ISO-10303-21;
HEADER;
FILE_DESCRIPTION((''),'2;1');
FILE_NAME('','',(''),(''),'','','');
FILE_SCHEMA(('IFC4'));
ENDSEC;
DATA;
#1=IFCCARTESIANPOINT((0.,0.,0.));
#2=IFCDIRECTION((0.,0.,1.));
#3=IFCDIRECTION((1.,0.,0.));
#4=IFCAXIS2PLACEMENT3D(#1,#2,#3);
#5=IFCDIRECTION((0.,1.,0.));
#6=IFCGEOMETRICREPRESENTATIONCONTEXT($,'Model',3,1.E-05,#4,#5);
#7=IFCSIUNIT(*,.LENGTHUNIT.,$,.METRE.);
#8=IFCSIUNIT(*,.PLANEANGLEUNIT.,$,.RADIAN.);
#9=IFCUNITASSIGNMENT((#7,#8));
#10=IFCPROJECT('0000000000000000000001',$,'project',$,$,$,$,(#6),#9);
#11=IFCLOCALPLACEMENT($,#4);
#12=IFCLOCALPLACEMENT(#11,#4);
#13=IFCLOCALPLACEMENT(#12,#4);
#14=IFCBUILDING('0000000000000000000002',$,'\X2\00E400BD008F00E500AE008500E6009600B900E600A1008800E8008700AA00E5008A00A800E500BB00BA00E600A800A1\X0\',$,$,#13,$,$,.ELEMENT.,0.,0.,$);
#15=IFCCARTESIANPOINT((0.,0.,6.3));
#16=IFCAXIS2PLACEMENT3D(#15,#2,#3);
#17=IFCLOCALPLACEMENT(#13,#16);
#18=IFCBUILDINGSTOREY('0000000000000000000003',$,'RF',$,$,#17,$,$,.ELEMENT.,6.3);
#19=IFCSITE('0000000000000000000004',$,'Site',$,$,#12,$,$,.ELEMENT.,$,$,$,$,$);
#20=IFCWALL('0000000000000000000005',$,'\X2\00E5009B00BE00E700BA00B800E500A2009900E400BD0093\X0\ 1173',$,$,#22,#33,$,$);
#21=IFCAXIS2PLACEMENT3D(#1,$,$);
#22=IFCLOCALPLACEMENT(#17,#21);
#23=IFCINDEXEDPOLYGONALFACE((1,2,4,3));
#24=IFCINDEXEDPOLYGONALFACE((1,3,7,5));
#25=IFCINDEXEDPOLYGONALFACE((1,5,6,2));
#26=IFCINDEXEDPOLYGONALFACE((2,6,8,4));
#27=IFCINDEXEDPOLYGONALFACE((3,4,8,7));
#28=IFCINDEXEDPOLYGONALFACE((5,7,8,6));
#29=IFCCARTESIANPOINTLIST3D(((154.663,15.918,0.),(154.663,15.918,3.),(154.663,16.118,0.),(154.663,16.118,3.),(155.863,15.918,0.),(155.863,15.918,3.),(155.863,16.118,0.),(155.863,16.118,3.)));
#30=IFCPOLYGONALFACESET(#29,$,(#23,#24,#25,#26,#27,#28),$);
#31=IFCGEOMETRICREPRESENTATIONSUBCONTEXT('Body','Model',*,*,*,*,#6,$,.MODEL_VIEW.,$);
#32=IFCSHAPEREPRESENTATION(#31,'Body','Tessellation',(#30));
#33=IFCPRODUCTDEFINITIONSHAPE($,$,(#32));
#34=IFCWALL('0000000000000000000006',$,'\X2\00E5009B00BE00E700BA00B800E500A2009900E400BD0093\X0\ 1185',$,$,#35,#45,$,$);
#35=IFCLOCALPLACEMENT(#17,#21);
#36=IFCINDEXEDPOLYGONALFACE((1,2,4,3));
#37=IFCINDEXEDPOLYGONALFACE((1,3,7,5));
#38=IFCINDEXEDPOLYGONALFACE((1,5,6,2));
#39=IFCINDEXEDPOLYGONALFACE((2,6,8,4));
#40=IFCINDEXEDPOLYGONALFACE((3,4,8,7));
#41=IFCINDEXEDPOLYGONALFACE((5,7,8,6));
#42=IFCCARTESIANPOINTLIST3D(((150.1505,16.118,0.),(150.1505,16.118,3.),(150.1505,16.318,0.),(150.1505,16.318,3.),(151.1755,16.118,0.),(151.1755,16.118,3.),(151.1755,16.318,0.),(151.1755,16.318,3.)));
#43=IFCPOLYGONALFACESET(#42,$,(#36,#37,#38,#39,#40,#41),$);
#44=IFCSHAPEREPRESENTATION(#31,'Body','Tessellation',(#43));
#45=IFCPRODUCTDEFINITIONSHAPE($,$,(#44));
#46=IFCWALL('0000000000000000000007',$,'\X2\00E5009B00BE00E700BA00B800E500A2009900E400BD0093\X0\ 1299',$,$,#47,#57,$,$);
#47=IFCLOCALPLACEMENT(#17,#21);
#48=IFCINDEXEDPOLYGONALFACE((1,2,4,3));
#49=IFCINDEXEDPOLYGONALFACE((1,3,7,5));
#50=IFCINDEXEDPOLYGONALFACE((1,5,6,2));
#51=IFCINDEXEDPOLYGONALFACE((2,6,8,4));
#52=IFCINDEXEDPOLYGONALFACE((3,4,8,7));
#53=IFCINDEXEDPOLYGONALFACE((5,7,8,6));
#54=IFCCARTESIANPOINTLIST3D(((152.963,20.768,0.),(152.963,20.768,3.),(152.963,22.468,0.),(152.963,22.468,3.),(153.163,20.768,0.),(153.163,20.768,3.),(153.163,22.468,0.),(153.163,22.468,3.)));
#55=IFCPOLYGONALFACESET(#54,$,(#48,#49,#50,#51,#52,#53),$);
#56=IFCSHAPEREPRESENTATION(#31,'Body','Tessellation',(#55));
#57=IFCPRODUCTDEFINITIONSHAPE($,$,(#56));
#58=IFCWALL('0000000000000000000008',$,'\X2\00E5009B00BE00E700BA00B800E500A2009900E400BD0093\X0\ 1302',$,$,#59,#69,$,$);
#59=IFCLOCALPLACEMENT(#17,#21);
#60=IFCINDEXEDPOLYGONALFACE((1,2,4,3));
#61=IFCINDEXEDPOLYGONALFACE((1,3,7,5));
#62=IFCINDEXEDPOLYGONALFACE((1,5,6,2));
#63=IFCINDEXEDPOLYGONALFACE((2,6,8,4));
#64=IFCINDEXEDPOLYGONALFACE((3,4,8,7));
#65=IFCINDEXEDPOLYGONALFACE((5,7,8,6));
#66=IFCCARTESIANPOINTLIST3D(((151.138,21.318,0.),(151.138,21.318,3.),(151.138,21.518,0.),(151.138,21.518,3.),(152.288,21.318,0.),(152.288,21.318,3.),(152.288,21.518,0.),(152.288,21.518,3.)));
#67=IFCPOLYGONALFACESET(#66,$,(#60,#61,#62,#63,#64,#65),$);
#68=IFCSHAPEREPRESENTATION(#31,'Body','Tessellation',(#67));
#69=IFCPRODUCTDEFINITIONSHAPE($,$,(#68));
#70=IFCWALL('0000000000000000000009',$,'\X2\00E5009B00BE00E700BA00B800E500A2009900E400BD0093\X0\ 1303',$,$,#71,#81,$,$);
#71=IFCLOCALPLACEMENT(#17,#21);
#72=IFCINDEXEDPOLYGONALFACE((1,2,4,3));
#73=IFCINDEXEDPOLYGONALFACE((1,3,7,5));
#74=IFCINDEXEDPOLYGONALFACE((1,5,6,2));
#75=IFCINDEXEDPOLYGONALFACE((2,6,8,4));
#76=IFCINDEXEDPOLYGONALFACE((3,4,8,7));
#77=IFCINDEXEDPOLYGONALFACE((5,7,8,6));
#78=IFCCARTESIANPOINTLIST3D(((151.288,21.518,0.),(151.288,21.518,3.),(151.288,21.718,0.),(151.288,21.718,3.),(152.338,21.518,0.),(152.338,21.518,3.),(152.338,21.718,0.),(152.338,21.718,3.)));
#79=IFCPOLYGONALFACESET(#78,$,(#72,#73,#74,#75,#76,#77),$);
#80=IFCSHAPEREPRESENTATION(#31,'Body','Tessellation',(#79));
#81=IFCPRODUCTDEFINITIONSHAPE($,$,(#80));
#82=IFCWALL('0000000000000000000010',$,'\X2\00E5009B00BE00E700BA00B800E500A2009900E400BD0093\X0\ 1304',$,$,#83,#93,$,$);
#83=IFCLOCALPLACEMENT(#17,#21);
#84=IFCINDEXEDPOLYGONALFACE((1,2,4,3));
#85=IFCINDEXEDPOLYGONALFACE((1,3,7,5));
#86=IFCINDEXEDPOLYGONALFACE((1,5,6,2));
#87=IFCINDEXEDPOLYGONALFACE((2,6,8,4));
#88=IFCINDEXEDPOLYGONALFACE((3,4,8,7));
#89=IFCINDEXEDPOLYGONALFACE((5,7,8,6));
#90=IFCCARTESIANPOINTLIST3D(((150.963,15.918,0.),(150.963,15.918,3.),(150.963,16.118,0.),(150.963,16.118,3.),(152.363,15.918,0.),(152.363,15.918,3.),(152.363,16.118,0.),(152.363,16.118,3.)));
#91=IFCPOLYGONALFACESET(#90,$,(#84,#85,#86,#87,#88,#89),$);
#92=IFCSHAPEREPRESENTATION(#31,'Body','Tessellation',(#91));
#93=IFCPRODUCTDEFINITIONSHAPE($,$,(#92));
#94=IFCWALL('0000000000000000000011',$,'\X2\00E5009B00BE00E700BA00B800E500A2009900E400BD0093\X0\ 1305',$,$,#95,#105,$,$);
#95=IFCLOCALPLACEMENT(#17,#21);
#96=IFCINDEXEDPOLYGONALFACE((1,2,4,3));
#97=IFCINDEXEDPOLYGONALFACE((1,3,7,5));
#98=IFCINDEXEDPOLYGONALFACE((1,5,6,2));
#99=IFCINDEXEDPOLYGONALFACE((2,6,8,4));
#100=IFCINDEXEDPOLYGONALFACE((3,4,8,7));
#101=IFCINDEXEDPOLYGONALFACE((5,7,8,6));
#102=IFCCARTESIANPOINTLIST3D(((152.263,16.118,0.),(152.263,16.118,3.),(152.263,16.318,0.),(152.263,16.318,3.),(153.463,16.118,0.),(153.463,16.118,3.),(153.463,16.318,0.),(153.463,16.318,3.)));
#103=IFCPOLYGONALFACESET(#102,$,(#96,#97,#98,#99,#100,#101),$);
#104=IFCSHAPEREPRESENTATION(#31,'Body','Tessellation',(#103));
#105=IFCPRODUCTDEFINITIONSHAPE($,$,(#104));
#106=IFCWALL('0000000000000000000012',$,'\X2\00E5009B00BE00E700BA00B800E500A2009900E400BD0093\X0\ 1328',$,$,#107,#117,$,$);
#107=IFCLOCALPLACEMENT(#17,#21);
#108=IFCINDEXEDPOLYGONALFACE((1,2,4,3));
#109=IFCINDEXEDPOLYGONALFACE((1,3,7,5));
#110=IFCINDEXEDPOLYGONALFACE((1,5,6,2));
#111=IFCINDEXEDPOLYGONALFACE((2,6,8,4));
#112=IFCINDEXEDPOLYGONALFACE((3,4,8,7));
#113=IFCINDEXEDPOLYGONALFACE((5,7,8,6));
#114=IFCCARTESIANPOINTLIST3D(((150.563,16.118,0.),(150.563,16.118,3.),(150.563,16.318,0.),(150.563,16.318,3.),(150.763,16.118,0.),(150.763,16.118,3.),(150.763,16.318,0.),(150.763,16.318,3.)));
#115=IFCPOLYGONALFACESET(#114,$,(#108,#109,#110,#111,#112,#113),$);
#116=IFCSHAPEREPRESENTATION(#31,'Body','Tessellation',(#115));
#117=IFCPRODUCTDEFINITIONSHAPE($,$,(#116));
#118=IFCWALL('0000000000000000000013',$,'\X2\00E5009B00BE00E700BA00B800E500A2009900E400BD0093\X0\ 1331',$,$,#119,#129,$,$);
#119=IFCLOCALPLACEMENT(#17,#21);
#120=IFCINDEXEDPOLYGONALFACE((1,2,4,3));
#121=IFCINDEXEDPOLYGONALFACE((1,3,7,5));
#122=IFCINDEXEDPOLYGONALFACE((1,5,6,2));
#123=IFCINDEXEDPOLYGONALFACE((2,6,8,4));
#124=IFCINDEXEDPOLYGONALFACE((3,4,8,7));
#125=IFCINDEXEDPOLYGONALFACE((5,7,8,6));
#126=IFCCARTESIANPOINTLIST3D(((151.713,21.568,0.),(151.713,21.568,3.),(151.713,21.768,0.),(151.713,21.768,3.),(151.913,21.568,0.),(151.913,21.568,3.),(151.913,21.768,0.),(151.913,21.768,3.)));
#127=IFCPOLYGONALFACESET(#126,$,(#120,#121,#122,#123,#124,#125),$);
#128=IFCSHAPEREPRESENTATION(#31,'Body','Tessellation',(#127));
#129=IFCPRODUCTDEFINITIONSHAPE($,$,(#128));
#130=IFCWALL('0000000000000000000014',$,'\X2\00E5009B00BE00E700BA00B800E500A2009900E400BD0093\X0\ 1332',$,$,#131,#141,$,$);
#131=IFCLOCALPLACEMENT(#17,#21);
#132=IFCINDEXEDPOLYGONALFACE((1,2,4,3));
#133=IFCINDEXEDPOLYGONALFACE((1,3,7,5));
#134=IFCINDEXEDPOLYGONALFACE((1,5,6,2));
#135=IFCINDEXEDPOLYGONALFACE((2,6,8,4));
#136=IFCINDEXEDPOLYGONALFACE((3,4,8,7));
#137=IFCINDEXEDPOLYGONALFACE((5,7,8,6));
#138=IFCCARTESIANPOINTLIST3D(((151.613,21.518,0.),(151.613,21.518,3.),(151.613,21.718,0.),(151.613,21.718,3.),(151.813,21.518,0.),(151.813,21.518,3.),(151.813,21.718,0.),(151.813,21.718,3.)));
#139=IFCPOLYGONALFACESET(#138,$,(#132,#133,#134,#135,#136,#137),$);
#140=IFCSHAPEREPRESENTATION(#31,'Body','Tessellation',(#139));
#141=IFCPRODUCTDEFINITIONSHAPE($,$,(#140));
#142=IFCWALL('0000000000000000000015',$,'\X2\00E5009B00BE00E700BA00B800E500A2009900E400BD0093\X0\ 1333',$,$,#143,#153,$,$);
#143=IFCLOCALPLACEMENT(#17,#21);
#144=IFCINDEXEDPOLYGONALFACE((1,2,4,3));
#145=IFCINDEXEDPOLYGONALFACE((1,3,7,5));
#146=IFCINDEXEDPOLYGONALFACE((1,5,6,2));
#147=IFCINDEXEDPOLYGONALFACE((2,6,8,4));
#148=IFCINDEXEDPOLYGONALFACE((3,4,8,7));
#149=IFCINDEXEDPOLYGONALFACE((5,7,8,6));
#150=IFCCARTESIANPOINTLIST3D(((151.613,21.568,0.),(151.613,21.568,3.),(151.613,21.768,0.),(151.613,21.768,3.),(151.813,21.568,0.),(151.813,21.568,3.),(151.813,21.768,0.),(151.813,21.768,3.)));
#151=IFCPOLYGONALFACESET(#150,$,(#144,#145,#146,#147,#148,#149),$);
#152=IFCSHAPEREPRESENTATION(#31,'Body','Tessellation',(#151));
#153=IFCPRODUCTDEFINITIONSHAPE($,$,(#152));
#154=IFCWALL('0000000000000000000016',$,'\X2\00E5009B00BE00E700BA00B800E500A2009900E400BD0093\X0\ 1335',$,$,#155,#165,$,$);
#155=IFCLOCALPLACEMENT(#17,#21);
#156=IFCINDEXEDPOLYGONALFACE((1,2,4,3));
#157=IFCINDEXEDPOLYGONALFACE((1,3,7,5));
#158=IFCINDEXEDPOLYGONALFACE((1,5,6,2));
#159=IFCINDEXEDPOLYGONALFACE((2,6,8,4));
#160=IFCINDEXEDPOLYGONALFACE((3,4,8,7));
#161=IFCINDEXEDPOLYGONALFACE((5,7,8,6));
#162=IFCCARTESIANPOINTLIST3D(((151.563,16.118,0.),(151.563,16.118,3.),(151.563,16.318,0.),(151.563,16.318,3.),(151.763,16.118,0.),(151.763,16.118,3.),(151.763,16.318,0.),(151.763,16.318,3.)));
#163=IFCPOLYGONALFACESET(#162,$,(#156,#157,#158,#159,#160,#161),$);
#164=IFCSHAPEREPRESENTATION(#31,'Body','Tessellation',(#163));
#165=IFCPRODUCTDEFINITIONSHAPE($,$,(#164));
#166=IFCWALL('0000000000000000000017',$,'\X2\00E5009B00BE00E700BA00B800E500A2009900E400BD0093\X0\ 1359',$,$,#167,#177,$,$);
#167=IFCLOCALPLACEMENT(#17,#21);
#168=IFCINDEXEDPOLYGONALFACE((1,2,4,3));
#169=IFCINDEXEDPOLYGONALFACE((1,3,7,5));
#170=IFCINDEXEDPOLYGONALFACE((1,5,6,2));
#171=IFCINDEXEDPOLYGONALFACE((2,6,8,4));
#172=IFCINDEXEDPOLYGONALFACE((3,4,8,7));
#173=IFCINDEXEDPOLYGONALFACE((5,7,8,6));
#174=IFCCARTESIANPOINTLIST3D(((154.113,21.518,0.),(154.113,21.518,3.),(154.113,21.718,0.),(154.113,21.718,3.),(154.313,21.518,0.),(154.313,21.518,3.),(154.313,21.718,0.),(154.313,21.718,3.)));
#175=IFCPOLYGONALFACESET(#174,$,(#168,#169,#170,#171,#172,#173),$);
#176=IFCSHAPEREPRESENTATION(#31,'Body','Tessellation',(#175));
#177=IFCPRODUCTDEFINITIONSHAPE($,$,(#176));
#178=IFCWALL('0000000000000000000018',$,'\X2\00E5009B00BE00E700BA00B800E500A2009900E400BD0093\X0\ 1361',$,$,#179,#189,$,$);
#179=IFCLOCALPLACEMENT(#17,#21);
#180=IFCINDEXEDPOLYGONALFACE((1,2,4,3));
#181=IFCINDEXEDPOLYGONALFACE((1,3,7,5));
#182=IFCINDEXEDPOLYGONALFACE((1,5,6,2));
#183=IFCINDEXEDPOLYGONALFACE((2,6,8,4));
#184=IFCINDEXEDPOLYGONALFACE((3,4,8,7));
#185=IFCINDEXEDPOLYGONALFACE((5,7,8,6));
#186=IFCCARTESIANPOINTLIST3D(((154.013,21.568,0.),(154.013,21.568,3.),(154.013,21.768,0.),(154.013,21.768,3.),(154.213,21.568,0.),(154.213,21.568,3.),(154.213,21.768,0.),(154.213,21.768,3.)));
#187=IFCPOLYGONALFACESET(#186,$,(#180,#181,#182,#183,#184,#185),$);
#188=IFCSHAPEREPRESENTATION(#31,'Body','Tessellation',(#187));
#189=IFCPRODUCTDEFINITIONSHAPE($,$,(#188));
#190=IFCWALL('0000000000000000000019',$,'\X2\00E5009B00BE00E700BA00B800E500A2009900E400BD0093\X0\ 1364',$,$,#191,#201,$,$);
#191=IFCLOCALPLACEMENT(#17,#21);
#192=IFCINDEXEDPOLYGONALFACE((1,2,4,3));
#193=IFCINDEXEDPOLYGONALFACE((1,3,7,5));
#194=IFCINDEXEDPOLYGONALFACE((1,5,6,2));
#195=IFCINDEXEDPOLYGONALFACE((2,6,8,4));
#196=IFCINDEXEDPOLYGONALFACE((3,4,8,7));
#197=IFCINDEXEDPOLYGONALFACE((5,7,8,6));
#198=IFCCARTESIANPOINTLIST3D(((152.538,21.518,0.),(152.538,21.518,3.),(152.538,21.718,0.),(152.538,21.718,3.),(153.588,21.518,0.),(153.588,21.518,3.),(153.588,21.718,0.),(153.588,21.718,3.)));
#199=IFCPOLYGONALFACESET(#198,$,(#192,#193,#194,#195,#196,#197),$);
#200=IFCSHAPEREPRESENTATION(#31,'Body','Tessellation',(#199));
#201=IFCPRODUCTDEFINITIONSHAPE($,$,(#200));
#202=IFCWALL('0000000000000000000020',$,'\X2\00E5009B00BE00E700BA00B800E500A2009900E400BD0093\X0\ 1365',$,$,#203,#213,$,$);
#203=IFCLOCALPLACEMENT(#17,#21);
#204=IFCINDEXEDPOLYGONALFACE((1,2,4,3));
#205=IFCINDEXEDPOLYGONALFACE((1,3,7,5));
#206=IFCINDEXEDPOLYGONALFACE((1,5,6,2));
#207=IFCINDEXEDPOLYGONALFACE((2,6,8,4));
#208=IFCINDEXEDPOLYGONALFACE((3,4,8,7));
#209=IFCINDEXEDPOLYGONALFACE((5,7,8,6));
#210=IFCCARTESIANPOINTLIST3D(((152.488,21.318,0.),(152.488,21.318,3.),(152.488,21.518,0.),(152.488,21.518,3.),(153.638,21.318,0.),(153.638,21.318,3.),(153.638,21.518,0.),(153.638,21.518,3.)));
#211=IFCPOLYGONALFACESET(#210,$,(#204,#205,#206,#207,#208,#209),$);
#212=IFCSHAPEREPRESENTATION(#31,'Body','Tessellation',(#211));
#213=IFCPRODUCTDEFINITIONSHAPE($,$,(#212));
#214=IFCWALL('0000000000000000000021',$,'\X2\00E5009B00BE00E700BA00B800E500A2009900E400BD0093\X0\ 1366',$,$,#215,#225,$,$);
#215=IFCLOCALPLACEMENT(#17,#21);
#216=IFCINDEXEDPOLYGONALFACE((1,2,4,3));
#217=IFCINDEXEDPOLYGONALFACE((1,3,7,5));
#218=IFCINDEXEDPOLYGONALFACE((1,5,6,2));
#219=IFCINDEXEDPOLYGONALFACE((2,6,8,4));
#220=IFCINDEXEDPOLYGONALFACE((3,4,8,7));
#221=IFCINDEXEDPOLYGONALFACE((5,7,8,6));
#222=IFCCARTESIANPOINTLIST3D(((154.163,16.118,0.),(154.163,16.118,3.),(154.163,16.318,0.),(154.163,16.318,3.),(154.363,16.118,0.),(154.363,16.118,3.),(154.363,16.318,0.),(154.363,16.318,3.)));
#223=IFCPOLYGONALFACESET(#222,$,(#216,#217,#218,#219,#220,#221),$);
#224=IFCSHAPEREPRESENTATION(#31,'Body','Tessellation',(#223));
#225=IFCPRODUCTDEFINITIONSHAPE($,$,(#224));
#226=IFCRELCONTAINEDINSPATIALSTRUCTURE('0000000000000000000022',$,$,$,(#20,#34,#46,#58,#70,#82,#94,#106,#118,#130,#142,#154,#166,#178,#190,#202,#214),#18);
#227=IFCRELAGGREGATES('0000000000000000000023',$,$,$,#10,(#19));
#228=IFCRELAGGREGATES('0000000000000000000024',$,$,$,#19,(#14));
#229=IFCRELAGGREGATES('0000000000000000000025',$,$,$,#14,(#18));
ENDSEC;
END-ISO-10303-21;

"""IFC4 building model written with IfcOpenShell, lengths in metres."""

from ifc_helpers import new_model, si_unit, direction, frame, frame_2d, origin_with_axes, place, context, subcontext, project, spatial, rectangle, extrude, element, save


model = new_model("IFC4")

# Units and contexts
model_context = context("Model", 3, precision=1e-05, world=origin_with_axes(), true_north=direction((0.0, 1.0, 0.0)))
body_context = subcontext(model_context, "Body", "Model", "MODEL_VIEW")
ifc_project = project(units=[si_unit("LENGTHUNIT", "METRE"), si_unit("PLANEANGLEUNIT", "RADIAN")], contexts=[model_context])

# Site, building, storey
placement = place(None, origin_with_axes())
site_placement = place(placement, origin_with_axes())
site = spatial("IfcSite", under=ifc_project, at=site_placement, Name="Site", CompositionType="ELEMENT")
building_placement = place(site_placement, origin_with_axes())
building = spatial("IfcBuilding", under=site, at=building_placement, Name="ä½\u008få®\u0085æ\u0096¹æ¡\u0088è\u0087ªå\u008a¨å»ºæ¨¡", CompositionType="ELEMENT", ElevationOfRefHeight=0.0, ElevationOfTerrain=0.0)
storey_placement = place(building_placement, frame((0.0, 0.0, 6.3), z_axis=(0.0, 0.0, 1.0), x_axis=(1.0, 0.0, 0.0)))
storey = spatial("IfcBuildingStorey", under=building, at=storey_placement, Name="RF", CompositionType="ELEMENT", Elevation=6.3)

# Walls
wall_1_placement = place(storey_placement, frame((155.263, 16.018, 0.0), z_axis=(0.0, 0.0, 1.0), x_axis=(1.0, 0.0, 0.0)))
element("IfcWall", 1, at=wall_1_placement, inside=storey, Name="å\u009b¾çº¸å¢\u0099ä½\u0093 1173", context=body_context, shape_type="SweptSolid", body=[
    extrude(rectangle(XDim=1.2, YDim=0.2, at=frame_2d((0.0, 0.0), x_axis=(1.0, 0.0, 0.0))), frame((0.0, 0.0, 0.0), z_axis=(0.0, 0.0, 1.0)), (0.0, 0.0, 1.0), 3.0),
])
wall_2_placement = place(storey_placement, frame((150.663, 16.218, 0.0), z_axis=(0.0, 0.0, 1.0), x_axis=(-1.0, 0.0, 0.0)))
element("IfcWall", 2, at=wall_2_placement, inside=storey, Name="å\u009b¾çº¸å¢\u0099ä½\u0093 1185", context=body_context, shape_type="SweptSolid", body=[
    extrude(rectangle(XDim=1.025, YDim=0.2, at=frame_2d((0.0, 0.0), x_axis=(1.0, 0.0, 0.0))), frame((0.0, 0.0, 0.0), z_axis=(0.0, 0.0, 1.0)), (0.0, 0.0, 1.0), 3.0),
])
wall_3_placement = place(storey_placement, frame((153.063, 21.618, 0.0), z_axis=(0.0, 0.0, 1.0), x_axis=(0.0, 1.0, 0.0)))
element("IfcWall", 3, at=wall_3_placement, inside=storey, Name="å\u009b¾çº¸å¢\u0099ä½\u0093 1299", context=body_context, shape_type="SweptSolid", body=[
    extrude(rectangle(XDim=1.7, YDim=0.2, at=frame_2d((0.0, 0.0), x_axis=(1.0, 0.0, 0.0))), frame((0.0, 0.0, 0.0), z_axis=(0.0, 0.0, 1.0)), (0.0, 0.0, 1.0), 3.0),
])
wall_4_placement = place(storey_placement, frame((151.713, 21.418, 0.0), z_axis=(0.0, 0.0, 1.0), x_axis=(1.0, 0.0, 0.0)))
element("IfcWall", 4, at=wall_4_placement, inside=storey, Name="å\u009b¾çº¸å¢\u0099ä½\u0093 1302", context=body_context, shape_type="SweptSolid", body=[
    extrude(rectangle(XDim=1.15, YDim=0.2, at=frame_2d((0.0, 0.0), x_axis=(1.0, 0.0, 0.0))), frame((0.0, 0.0, 0.0), z_axis=(0.0, 0.0, 1.0)), (0.0, 0.0, 1.0), 3.0),
])
wall_5_placement = place(storey_placement, frame((151.813, 21.618, 0.0), z_axis=(0.0, 0.0, 1.0), x_axis=(1.0, 0.0, 0.0)))
element("IfcWall", 5, at=wall_5_placement, inside=storey, Name="å\u009b¾çº¸å¢\u0099ä½\u0093 1303", context=body_context, shape_type="SweptSolid", body=[
    extrude(rectangle(XDim=1.05, YDim=0.2, at=frame_2d((0.0, 0.0), x_axis=(1.0, 0.0, 0.0))), frame((0.0, 0.0, 0.0), z_axis=(0.0, 0.0, 1.0)), (0.0, 0.0, 1.0), 3.0),
])
wall_6_placement = place(storey_placement, frame((151.663, 16.018, 0.0), z_axis=(0.0, 0.0, 1.0), x_axis=(1.0, 0.0, 0.0)))
element("IfcWall", 6, at=wall_6_placement, inside=storey, Name="å\u009b¾çº¸å¢\u0099ä½\u0093 1304", context=body_context, shape_type="SweptSolid", body=[
    extrude(rectangle(XDim=1.4, YDim=0.2, at=frame_2d((0.0, 0.0), x_axis=(1.0, 0.0, 0.0))), frame((0.0, 0.0, 0.0), z_axis=(0.0, 0.0, 1.0)), (0.0, 0.0, 1.0), 3.0),
])
wall_7_placement = place(storey_placement, frame((152.863, 16.218, 0.0), z_axis=(0.0, 0.0, 1.0), x_axis=(-1.0, 0.0, 0.0)))
element("IfcWall", 7, at=wall_7_placement, inside=storey, Name="å\u009b¾çº¸å¢\u0099ä½\u0093 1305", context=body_context, shape_type="SweptSolid", body=[
    extrude(rectangle(XDim=1.2, YDim=0.2, at=frame_2d((0.0, 0.0), x_axis=(1.0, 0.0, 0.0))), frame((0.0, 0.0, 0.0), z_axis=(0.0, 0.0, 1.0)), (0.0, 0.0, 1.0), 3.0),
])
for number, where, z_axis, x_axis, name in (
    (8, (150.663, 16.218, 0.0), (0.0, 0.0, 1.0), (0.0, -1.0, 0.0), "å\u009b¾çº¸å¢\u0099ä½\u0093 1328"),
    (9, (151.813, 21.668, 0.0), (0.0, 0.0, 1.0), (-1.0, 0.0, 0.0), "å\u009b¾çº¸å¢\u0099ä½\u0093 1331"),
    (10, (151.713, 21.618, 0.0), (0.0, 0.0, 1.0), (0.0, -1.0, 0.0), "å\u009b¾çº¸å¢\u0099ä½\u0093 1332"),
    (11, (151.713, 21.668, 0.0), (0.0, 0.0, 1.0), (0.0, -1.0, 0.0), "å\u009b¾çº¸å¢\u0099ä½\u0093 1333"),
    (12, (151.663, 16.218, 0.0), (0.0, 0.0, 1.0), (0.0, -1.0, 0.0), "å\u009b¾çº¸å¢\u0099ä½\u0093 1335"),
    (13, (154.213, 21.618, 0.0), (0.0, 0.0, 1.0), (0.0, -1.0, 0.0), "å\u009b¾çº¸å¢\u0099ä½\u0093 1359"),
    (14, (154.113, 21.668, 0.0), (0.0, 0.0, 1.0), (1.0, 0.0, 0.0), "å\u009b¾çº¸å¢\u0099ä½\u0093 1361"),
):
    element("IfcWall", number, at=place(storey_placement, frame(where, z_axis=z_axis, x_axis=x_axis)), inside=storey, Name=name, context=body_context, shape_type="SweptSolid", body=[
        extrude(rectangle(XDim=0.2, YDim=0.2, at=frame_2d((0.0, 0.0), x_axis=(1.0, 0.0, 0.0))), frame((0.0, 0.0, 0.0), z_axis=(0.0, 0.0, 1.0)), (0.0, 0.0, 1.0), 3.0),
    ])
wall_8_placement = place(storey_placement, frame((153.063, 21.618, 0.0), z_axis=(0.0, 0.0, 1.0), x_axis=(1.0, 0.0, 0.0)))
element("IfcWall", 15, at=wall_8_placement, inside=storey, Name="å\u009b¾çº¸å¢\u0099ä½\u0093 1364", context=body_context, shape_type="SweptSolid", body=[
    extrude(rectangle(XDim=1.05, YDim=0.2, at=frame_2d((0.0, 0.0), x_axis=(1.0, 0.0, 0.0))), frame((0.0, 0.0, 0.0), z_axis=(0.0, 0.0, 1.0)), (0.0, 0.0, 1.0), 3.0),
])
wall_9_placement = place(storey_placement, frame((153.063, 21.418, 0.0), z_axis=(0.0, 0.0, 1.0), x_axis=(1.0, 0.0, 0.0)))
element("IfcWall", 16, at=wall_9_placement, inside=storey, Name="å\u009b¾çº¸å¢\u0099ä½\u0093 1365", context=body_context, shape_type="SweptSolid", body=[
    extrude(rectangle(XDim=1.15, YDim=0.2, at=frame_2d((0.0, 0.0), x_axis=(1.0, 0.0, 0.0))), frame((0.0, 0.0, 0.0), z_axis=(0.0, 0.0, 1.0)), (0.0, 0.0, 1.0), 3.0),
])
wall_10_placement = place(storey_placement, frame((154.263, 16.218, 0.0), z_axis=(0.0, 0.0, 1.0), x_axis=(0.0, -1.0, 0.0)))
element("IfcWall", 17, at=wall_10_placement, inside=storey, Name="å\u009b¾çº¸å¢\u0099ä½\u0093 1366", context=body_context, shape_type="SweptSolid", body=[
    extrude(rectangle(XDim=0.2, YDim=0.2, at=frame_2d((0.0, 0.0), x_axis=(1.0, 0.0, 0.0))), frame((0.0, 0.0, 0.0), z_axis=(0.0, 0.0, 1.0)), (0.0, 0.0, 1.0), 3.0),
])

save(model, "model.ifc")
